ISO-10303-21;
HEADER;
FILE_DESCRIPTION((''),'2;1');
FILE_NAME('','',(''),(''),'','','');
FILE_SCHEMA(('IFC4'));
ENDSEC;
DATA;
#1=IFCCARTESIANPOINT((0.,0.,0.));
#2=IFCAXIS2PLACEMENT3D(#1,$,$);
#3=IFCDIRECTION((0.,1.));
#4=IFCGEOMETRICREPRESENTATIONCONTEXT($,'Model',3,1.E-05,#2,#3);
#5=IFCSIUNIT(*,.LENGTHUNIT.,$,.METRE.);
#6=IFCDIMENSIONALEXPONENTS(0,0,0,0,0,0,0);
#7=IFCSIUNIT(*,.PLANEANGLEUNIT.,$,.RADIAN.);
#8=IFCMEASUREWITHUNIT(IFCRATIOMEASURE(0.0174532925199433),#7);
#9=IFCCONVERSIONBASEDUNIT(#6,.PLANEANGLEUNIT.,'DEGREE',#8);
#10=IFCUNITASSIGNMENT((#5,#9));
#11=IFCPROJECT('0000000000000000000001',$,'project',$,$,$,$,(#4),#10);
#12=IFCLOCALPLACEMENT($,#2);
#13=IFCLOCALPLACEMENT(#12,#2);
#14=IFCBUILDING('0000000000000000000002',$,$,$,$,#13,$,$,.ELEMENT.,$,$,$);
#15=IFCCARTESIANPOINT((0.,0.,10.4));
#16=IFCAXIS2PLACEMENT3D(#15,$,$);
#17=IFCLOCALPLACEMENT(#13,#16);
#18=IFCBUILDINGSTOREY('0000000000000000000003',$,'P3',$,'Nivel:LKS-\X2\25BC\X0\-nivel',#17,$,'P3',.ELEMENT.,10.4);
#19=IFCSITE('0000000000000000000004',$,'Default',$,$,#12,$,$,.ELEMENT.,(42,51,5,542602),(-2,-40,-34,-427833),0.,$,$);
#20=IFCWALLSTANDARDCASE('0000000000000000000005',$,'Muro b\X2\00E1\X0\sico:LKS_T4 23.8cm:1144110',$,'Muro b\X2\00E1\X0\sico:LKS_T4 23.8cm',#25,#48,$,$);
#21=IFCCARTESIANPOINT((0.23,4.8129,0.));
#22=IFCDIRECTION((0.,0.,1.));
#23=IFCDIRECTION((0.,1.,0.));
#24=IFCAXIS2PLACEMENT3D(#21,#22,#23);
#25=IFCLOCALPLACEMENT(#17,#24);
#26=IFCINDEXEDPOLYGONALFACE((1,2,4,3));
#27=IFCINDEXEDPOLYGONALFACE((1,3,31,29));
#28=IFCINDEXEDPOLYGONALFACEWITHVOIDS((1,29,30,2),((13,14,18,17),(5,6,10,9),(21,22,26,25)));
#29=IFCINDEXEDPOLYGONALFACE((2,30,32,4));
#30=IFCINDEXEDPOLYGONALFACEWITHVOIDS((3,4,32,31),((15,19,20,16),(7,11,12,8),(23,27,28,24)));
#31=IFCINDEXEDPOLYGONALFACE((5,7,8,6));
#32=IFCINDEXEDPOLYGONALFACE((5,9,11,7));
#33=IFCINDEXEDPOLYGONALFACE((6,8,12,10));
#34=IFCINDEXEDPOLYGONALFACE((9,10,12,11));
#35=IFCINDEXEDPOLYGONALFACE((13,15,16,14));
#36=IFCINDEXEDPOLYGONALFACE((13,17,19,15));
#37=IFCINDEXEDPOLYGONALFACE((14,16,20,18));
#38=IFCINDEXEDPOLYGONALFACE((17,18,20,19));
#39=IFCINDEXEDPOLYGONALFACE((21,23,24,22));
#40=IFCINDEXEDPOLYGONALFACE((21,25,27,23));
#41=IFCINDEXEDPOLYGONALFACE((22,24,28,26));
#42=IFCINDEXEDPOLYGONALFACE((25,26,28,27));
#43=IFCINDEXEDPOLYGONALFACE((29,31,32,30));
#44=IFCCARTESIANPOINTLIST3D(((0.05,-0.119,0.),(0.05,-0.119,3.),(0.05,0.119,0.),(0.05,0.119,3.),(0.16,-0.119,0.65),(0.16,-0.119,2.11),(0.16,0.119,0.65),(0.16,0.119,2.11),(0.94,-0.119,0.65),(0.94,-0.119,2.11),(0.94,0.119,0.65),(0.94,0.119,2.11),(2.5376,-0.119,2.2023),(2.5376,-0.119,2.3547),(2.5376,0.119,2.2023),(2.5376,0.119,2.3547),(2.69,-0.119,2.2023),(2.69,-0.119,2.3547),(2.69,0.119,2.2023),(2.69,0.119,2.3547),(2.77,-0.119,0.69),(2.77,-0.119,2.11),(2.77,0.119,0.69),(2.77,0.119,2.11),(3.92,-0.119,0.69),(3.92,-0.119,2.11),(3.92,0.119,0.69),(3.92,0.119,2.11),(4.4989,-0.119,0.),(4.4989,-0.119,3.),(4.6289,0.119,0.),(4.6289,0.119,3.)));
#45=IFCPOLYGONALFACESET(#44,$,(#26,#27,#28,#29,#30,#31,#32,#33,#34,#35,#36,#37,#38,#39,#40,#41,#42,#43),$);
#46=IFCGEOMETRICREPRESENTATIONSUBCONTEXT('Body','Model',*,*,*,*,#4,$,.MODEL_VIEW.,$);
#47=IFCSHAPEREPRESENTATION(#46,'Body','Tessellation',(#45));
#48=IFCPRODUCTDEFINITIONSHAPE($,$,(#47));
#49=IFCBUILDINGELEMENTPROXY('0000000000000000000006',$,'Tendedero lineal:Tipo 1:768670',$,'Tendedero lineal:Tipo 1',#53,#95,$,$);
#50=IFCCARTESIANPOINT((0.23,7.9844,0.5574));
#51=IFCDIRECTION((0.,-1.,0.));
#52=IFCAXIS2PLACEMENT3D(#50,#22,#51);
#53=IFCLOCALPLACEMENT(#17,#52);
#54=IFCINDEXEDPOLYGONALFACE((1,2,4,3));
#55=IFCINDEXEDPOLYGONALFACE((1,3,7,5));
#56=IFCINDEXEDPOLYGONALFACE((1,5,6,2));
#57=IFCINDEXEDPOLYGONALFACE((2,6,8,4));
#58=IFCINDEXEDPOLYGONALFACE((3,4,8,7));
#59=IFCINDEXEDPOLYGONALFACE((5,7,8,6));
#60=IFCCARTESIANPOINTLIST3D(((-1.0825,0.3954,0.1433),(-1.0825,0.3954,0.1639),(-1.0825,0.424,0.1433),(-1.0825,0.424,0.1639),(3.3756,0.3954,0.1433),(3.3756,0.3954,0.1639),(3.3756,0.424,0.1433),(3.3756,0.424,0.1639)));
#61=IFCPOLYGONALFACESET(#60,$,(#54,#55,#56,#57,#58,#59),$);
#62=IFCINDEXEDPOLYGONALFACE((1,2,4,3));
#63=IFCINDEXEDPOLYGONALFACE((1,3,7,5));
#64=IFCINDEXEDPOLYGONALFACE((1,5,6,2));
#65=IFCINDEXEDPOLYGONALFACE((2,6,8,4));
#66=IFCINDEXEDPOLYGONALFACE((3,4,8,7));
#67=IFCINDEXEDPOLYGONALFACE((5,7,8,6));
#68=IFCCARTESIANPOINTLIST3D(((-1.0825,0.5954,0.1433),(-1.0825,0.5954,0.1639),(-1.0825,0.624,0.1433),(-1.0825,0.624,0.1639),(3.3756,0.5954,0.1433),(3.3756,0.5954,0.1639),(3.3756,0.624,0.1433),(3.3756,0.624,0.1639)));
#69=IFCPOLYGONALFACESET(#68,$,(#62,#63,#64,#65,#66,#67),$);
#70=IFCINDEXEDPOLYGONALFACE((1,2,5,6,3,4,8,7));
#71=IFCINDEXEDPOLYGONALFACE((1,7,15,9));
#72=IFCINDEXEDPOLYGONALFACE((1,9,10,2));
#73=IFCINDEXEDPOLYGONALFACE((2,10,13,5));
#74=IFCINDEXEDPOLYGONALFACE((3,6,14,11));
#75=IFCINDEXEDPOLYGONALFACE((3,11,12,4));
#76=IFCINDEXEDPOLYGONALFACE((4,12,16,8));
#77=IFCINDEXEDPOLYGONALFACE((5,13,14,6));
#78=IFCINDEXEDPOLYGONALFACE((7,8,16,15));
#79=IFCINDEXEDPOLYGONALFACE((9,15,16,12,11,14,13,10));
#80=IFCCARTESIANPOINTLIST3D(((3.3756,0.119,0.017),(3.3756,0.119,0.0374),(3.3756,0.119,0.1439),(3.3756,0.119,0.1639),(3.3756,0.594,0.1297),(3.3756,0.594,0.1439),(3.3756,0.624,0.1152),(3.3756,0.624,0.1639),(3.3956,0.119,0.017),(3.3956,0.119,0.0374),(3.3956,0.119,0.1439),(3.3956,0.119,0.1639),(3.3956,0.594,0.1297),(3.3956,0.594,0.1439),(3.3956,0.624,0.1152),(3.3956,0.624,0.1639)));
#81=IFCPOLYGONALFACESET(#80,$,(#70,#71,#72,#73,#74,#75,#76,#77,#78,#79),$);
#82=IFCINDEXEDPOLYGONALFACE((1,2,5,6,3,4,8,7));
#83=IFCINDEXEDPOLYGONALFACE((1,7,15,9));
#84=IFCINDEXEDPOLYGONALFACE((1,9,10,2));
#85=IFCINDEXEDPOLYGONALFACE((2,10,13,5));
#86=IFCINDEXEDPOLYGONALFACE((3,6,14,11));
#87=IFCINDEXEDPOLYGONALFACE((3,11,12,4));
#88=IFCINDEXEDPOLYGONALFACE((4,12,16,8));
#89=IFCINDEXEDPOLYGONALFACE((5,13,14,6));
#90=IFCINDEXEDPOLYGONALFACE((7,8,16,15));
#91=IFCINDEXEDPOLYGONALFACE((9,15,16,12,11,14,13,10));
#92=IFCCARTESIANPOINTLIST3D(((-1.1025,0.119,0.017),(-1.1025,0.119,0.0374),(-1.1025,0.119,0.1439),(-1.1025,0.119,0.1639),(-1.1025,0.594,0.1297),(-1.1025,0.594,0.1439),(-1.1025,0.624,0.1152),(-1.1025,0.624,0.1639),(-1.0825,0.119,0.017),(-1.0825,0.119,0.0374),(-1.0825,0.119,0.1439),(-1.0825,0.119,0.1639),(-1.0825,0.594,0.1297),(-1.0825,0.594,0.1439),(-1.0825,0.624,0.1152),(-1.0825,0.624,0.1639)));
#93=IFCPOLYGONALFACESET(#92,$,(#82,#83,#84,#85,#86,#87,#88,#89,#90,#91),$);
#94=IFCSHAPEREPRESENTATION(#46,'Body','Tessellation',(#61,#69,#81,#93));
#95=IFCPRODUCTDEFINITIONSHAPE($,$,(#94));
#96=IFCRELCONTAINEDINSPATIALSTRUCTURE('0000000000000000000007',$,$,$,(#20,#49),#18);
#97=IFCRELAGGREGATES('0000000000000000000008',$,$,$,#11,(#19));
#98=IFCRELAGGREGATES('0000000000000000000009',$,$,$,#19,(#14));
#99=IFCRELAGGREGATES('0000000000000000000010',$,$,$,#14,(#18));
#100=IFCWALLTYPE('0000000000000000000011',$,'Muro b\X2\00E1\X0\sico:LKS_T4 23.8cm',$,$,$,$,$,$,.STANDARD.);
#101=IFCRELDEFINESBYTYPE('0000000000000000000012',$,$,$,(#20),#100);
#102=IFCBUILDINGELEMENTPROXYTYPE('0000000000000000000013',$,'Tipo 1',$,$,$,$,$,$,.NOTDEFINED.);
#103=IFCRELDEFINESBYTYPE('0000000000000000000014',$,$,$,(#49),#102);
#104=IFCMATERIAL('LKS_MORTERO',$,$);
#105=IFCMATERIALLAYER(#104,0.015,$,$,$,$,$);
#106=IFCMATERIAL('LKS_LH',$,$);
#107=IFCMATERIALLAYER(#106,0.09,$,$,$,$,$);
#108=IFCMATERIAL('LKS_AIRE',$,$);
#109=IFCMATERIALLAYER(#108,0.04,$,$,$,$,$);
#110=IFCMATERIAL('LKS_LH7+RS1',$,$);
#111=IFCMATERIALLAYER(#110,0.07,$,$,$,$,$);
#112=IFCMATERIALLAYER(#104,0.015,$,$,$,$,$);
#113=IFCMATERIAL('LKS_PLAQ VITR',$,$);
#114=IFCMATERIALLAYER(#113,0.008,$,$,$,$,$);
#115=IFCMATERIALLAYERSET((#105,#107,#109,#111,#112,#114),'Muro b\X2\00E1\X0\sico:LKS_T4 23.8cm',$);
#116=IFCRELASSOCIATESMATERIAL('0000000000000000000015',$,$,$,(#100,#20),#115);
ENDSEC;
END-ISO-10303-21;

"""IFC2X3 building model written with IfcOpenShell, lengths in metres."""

from ifc_helpers import new_model, entity, si_unit, converted_unit, direction, frame, frame_2d, origin, origin_2d_with_axis, place, context, subcontext, project, spatial, polyline, rectangle, outline, extrude, source, transform, mapped, material, layer, layer_set, layer_usage, type_object, type_shapes, element, save


model = new_model("IFC2X3")

# Units and contexts
model_context = context("Model", 3, precision=1e-05, world=origin(), true_north=direction((0.0, 1.0)))
body_context = subcontext(model_context, "Body", "Model", "MODEL_VIEW")
ifc_project = project(units=[si_unit("LENGTHUNIT", "METRE"), converted_unit("PLANEANGLEUNIT", "DEGREE", entity("IfcRatioMeasure", 0.0174532925199433), si_unit("PLANEANGLEUNIT", "RADIAN"), dimensions=[0, 0, 0, 0, 0, 0, 0])], contexts=[model_context])

# Site, building, storey
site_placement = place(None, origin())
site = spatial("IfcSite", under=ifc_project, at=site_placement, Name="Default", CompositionType="ELEMENT", RefLatitude=(42, 51, 5, 542602), RefLongitude=(-2, -40, -34, -427833), RefElevation=0.0)
building_placement = place(site_placement, origin())
building = spatial("IfcBuilding", under=site, at=building_placement, CompositionType="ELEMENT")
storey_placement = place(building_placement, frame((0.0, 0.0, 10.4)))
storey = spatial("IfcBuildingStorey", under=building, at=storey_placement, Name="P3", ObjectType="Nivel:LKS-▼-nivel", LongName="P3", CompositionType="ELEMENT", Elevation=10.4)

# Shared definitions
ifc_material_1 = material(Name="LKS_MORTERO")
ifc_material_2 = material(Name="LKS_PLAQ VITR")

# Wall, openings
ifc_layer_1 = layer(ifc_material_1, 0.015)
ifc_material_3 = material(Name="LKS_LH")
ifc_layer_2 = layer(ifc_material_3, 0.09)
ifc_material_4 = material(Name="LKS_AIRE")
ifc_layer_3 = layer(ifc_material_4, 0.04)
ifc_material_5 = material(Name="LKS_LH7+RS1")
ifc_layer_4 = layer(ifc_material_5, 0.07)
ifc_layer_5 = layer(ifc_material_1, 0.015)
ifc_layer_6 = layer(ifc_material_2, 0.008)
ifc_layer_set_1 = layer_set([ifc_layer_1, ifc_layer_2, ifc_layer_3, ifc_layer_4, ifc_layer_5, ifc_layer_6], Name="Muro básico:LKS_T4 23.8cm")
ifc_layer_usage_1 = layer_usage(ifc_layer_set_1, "AXIS2", "NEGATIVE", 0.119)
wall_type_1 = type_object("IfcWallType", Name="Muro básico:LKS_T4 23.8cm", PredefinedType="STANDARD", material=ifc_layer_set_1)
wall_1_placement = place(storey_placement, frame((0.23, 4.8129, 0.0), z_axis=(0.0, 0.0, 1.0), x_axis=(0.0, 1.0, 0.0)))
wall_1 = element("IfcWallStandardCase", 1, at=wall_1_placement, inside=storey, type_object=wall_type_1, material=ifc_layer_usage_1, Name="Muro básico:LKS_T4 23.8cm:1144110", ObjectType="Muro básico:LKS_T4 23.8cm", context=body_context, shape_type="SweptSolid", body=[
    extrude(outline(polyline([(4.4989, -0.119), (4.6289, 0.119), (4.4489, 0.119), (1.85, 0.119), (1.75, 0.119), (0.05, 0.119), (0.05, 0.111), (0.05, -0.119), (4.4989, -0.119)])), origin(), (0.0, 0.0, 1.0), 3.0),
])
opening_1_placement = place(wall_1_placement, origin())
element("IfcOpeningElement", 2, at=opening_1_placement, cuts=wall_1, ObjectType="Opening", context=body_context, shape_type="SweptSolid", body=[
    extrude(rectangle(XDim=0.1524, YDim=0.1524, at=frame_2d((0.0, 0.0), x_axis=(0.0, 1.0))), frame((2.6138, -1.405, 2.2785), z_axis=(0.0, 1.0, 0.0), x_axis=(-1.0, 0.0, 0.0)), (0.0, 0.0, 1.0), 3.048),
])
opening_2_placement = place(wall_1_placement, frame((3.92, 0.119, 0.69)))
element("IfcOpeningElement", 3, at=opening_2_placement, cuts=wall_1, ObjectType="Opening", context=body_context, shape_type="SweptSolid", body=[
    extrude(rectangle(XDim=1.42, YDim=1.15, at=frame_2d((0.71, 0.575), x_axis=(1.0, 0.0))), frame((0.0, 0.0, 0.0), z_axis=(0.0, -1.0, 0.0), x_axis=(0.0, 0.0, 1.0)), (0.0, 0.0, 1.0), 0.238),
])
opening_3_placement = place(wall_1_placement, frame((0.16, -0.119, 0.65)))
element("IfcOpeningElement", 4, at=opening_3_placement, cuts=wall_1, ObjectType="Opening", context=body_context, shape_type="SweptSolid", body=[
    extrude(rectangle(XDim=1.46, YDim=0.78, at=frame_2d((0.73, 0.39), x_axis=(1.0, 0.0))), frame((0.0, 0.0, 0.0), z_axis=(0.0, 1.0, 0.0), x_axis=(0.0, 0.0, 1.0)), (0.0, 0.0, 1.0), 0.238),
])

# Building element proxy
building_element_proxy_type_1 = type_object("IfcBuildingElementProxyType", Name="Tipo 1", PredefinedType="NOTDEFINED")
shared_shape_1 = source(origin(), body_context, "Body", "SweptSolid", [
    extrude(rectangle(XDim=4.4581, YDim=0.0286, at=origin_2d_with_axis()), frame((1.1466, 0.4097, 0.1433), z_axis=(0.0, 0.0, 1.0), x_axis=(-1.0, 0.0, 0.0)), (0.0, 0.0, 1.0), 0.0206),
    extrude(rectangle(XDim=4.4581, YDim=0.0286, at=origin_2d_with_axis()), frame((1.1466, 0.6097, 0.1433), z_axis=(0.0, 0.0, 1.0), x_axis=(-1.0, 0.0, 0.0)), (0.0, 0.0, 1.0), 0.0206),
    extrude(outline(polyline([(-0.26, -0.0495), (0.245, -0.0495), (0.245, -0.0295), (-0.23, -0.0295), (-0.23, -0.0154), (0.245, 0.077), (0.245, 0.0973), (-0.26, -0.0008), (-0.26, -0.0495)])), frame((3.3756, 0.364, 0.1144), z_axis=(1.0, 0.0, 0.0), x_axis=(0.0, -1.0, 0.0)), (0.0, 0.0, 1.0), 0.02),
    extrude(outline(polyline([(-0.26, -0.0495), (0.245, -0.0495), (0.245, -0.0295), (-0.23, -0.0295), (-0.23, -0.0154), (0.245, 0.077), (0.245, 0.0973), (-0.26, -0.0008), (-0.26, -0.0495)])), frame((-1.1025, 0.364, 0.1144), z_axis=(1.0, 0.0, 0.0), x_axis=(0.0, -1.0, 0.0)), (0.0, 0.0, 1.0), 0.02),
])
type_shapes(building_element_proxy_type_1, [shared_shape_1])
proxy_1_placement = place(storey_placement, frame((0.23, 7.9844, 0.5574), z_axis=(0.0, 0.0, 1.0), x_axis=(0.0, -1.0, 0.0)))
element("IfcBuildingElementProxy", 5, at=proxy_1_placement, inside=storey, type_object=building_element_proxy_type_1, Name="Tendedero lineal:Tipo 1:768670", ObjectType="Tendedero lineal:Tipo 1", context=body_context, shape_type="MappedRepresentation", body=[
    mapped(shared_shape_1, transform((0.0, 0.0, 0.0), scale=1.0)),
])

save(model, "model.ifc")
